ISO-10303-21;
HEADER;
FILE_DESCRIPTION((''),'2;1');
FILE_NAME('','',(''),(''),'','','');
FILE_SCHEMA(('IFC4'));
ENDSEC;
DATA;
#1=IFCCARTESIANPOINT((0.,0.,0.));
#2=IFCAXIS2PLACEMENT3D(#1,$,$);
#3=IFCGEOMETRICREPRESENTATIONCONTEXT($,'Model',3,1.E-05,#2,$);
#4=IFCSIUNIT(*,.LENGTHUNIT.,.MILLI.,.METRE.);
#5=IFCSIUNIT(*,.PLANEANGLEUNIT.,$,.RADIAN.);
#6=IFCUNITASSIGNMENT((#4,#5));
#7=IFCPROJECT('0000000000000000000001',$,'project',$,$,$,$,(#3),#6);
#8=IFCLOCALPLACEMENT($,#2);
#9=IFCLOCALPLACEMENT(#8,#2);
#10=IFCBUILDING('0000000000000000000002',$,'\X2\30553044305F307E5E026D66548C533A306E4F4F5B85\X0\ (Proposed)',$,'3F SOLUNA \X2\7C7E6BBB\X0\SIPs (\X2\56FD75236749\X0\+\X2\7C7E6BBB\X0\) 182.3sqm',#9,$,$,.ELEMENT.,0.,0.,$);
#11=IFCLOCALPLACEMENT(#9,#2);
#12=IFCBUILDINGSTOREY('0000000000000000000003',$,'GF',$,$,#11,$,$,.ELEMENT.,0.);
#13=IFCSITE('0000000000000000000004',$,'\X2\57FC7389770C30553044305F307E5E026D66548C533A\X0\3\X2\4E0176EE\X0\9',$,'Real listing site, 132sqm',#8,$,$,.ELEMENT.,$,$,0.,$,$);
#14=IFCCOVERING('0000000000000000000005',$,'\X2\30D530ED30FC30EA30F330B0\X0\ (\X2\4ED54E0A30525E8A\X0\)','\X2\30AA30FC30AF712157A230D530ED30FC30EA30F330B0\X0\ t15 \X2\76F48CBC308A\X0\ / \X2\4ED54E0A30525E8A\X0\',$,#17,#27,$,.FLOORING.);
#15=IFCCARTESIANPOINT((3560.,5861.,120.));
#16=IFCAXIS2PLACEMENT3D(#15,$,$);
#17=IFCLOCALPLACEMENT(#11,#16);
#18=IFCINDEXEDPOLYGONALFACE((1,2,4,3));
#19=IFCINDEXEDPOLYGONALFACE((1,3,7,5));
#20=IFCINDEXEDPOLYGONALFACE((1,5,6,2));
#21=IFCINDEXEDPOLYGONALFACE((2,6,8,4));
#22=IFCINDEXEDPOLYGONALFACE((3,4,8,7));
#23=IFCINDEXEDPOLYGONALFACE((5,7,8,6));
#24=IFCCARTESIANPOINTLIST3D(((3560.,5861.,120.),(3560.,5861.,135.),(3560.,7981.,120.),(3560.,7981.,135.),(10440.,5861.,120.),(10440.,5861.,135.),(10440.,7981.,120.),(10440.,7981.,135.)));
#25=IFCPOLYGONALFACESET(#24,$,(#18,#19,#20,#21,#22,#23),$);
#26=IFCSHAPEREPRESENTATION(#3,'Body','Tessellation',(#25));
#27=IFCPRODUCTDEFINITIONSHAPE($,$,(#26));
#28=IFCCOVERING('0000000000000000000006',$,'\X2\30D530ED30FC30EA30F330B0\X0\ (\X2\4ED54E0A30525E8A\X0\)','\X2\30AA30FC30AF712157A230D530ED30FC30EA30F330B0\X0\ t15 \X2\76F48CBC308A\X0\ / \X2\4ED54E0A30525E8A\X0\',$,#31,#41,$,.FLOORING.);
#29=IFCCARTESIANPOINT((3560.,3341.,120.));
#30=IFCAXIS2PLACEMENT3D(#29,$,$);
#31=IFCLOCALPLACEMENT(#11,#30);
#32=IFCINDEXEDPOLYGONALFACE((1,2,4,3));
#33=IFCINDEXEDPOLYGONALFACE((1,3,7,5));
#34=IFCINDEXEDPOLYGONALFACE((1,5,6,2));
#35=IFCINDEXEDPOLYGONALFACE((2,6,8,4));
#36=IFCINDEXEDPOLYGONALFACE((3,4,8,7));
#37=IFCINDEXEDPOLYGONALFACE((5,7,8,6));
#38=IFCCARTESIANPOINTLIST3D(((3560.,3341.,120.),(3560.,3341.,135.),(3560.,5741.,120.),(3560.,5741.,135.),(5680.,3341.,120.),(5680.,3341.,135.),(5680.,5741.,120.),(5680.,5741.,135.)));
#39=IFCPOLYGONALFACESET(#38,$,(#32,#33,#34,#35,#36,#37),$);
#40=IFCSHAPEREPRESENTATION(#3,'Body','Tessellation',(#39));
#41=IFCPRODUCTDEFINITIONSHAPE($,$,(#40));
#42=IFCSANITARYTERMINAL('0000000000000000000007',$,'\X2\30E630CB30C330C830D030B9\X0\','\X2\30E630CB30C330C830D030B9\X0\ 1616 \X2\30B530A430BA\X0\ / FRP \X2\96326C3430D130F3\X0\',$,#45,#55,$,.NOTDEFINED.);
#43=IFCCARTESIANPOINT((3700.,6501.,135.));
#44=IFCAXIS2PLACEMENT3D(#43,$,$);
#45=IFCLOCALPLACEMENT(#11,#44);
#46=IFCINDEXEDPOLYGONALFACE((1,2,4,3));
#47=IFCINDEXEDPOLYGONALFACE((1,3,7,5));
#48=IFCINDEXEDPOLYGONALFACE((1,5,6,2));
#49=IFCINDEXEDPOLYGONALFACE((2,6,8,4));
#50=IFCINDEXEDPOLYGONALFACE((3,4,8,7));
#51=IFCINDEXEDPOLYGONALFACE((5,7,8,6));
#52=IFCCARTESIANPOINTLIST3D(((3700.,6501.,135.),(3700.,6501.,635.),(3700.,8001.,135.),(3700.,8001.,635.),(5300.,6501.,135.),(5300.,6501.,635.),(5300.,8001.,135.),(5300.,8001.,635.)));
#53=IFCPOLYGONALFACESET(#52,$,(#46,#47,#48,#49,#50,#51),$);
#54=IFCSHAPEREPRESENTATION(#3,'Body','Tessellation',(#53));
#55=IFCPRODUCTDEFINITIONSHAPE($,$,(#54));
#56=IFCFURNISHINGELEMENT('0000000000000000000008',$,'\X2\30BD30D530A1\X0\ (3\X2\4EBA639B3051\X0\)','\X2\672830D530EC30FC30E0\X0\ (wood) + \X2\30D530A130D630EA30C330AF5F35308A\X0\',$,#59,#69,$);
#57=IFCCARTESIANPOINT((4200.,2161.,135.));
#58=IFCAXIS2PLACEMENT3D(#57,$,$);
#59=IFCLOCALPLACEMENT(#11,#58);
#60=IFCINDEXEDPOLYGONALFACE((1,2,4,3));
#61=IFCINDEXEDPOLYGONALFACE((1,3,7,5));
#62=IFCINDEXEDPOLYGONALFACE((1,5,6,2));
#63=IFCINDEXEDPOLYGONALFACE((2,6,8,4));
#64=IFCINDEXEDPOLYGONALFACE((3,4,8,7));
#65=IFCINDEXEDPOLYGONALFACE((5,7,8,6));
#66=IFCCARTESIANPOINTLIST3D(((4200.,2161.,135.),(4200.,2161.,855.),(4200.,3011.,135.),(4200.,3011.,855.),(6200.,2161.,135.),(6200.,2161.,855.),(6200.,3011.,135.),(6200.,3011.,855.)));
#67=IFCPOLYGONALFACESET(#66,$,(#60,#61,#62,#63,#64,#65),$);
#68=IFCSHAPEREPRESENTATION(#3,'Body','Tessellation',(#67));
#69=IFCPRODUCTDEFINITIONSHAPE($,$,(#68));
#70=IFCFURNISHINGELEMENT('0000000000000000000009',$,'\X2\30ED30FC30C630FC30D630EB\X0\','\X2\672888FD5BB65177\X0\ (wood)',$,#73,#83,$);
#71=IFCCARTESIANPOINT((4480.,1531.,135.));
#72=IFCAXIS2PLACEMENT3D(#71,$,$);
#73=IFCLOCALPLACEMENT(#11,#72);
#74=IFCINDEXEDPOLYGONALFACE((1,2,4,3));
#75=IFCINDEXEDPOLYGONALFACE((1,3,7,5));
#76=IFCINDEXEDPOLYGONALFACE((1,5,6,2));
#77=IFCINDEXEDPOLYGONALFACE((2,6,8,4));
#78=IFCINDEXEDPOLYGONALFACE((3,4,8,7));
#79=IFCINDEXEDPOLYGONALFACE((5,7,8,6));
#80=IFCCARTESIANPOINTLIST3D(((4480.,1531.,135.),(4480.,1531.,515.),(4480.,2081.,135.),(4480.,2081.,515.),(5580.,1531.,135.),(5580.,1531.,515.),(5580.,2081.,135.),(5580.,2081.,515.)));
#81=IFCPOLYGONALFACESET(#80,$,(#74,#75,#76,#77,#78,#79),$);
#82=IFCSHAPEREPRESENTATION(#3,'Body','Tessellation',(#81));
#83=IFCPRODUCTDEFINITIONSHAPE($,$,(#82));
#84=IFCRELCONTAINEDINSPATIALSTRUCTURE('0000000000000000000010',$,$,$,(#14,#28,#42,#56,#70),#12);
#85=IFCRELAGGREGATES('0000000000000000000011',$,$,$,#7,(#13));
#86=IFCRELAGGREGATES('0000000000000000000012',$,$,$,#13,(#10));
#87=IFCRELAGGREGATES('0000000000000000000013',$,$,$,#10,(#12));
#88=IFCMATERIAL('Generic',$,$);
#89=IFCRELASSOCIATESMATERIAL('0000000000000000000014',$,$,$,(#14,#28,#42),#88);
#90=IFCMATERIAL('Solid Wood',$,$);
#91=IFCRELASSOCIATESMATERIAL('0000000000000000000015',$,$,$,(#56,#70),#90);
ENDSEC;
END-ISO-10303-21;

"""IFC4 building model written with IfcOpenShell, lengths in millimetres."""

from ifc_helpers import new_model, si_unit, frame, frame_2d, origin, place, context, project, spatial, rectangle, extrude, material, element, save


model = new_model("IFC4")

# Units and contexts
model_context = context("Model", 3, precision=1e-05, world=origin())
ifc_project = project(units=[si_unit("LENGTHUNIT", "METRE", prefix="MILLI"), si_unit("PLANEANGLEUNIT", "RADIAN")], contexts=[model_context])

# Site, building, storey
site_placement = place(None, origin())
site = spatial("IfcSite", under=ifc_project, at=site_placement, Name="埼玉県さいたま市浦和区3丁目9", ObjectType="Real listing site, 132sqm", CompositionType="ELEMENT", RefElevation=0.0)
building_placement = place(site_placement, origin())
building = spatial("IfcBuilding", under=site, at=building_placement, Name="さいたま市浦和区の住宅 (Proposed)", ObjectType="3F SOLUNA 籾殻SIPs (国産杉+籾殻) 182.3sqm", CompositionType="ELEMENT", ElevationOfRefHeight=0.0, ElevationOfTerrain=0.0)
storey_placement = place(building_placement, origin())
storey = spatial("IfcBuildingStorey", under=building, at=storey_placement, Name="GF", CompositionType="ELEMENT", Elevation=0.0)

# Shared definitions
ifc_material_1 = material(Name="Solid Wood")

# Coverings
ifc_material_2 = material(Name="Generic")
covering_1_placement = place(storey_placement, frame((3560.0, 5861.0, 120.0)))
element("IfcCovering", 1, at=covering_1_placement, inside=storey, material=ifc_material_2, Name="フローリング (仕上げ床)", Description="オーク無垢フローリング t15 直貼り / 仕上げ床", PredefinedType="FLOORING", context=model_context, shape_type="SweptSolid", body=[
    extrude(rectangle(XDim=6880.0, YDim=2120.0, at=frame_2d((3440.0, 1060.0))), frame((3560.0, 5861.0, 120.0)), (0.0, 0.0, 1.0), 15.0),
])
covering_2_placement = place(storey_placement, frame((3560.0, 3341.0, 120.0)))
element("IfcCovering", 2, at=covering_2_placement, inside=storey, material=ifc_material_2, Name="フローリング (仕上げ床)", Description="オーク無垢フローリング t15 直貼り / 仕上げ床", PredefinedType="FLOORING", context=model_context, shape_type="SweptSolid", body=[
    extrude(rectangle(XDim=2120.0, YDim=2400.0, at=frame_2d((1060.0, 1200.0))), frame((3560.0, 3341.0, 120.0)), (0.0, 0.0, 1.0), 15.0),
])

# Sanitary terminal
sanitary_terminal_placement = place(storey_placement, frame((3700.0, 6501.0, 135.0)))
element("IfcSanitaryTerminal", 3, at=sanitary_terminal_placement, inside=storey, material=ifc_material_2, Name="ユニットバス", Description="ユニットバス 1616 サイズ / FRP 防水パン", PredefinedType="NOTDEFINED", context=model_context, shape_type="SweptSolid", body=[
    extrude(rectangle(XDim=1600.0, YDim=1500.0, at=frame_2d((800.0, 750.0))), frame((3700.0, 6501.0, 135.0)), (0.0, 0.0, 1.0), 500.0),
])

# Furnishing elements
furnishing_1_placement = place(storey_placement, frame((4200.0, 2161.0, 135.0)))
element("IfcFurnishingElement", 4, at=furnishing_1_placement, inside=storey, material=ifc_material_1, Name="ソファ (3人掛け)", Description="木フレーム (wood) + ファブリック張り", context=model_context, shape_type="SweptSolid", body=[
    extrude(rectangle(XDim=2000.0, YDim=850.0, at=frame_2d((1000.0, 425.0))), frame((4200.0, 2161.0, 135.0)), (0.0, 0.0, 1.0), 720.0),
])
furnishing_2_placement = place(storey_placement, frame((4480.0, 1531.0, 135.0)))
element("IfcFurnishingElement", 5, at=furnishing_2_placement, inside=storey, material=ifc_material_1, Name="ローテーブル", Description="木製家具 (wood)", context=model_context, shape_type="SweptSolid", body=[
    extrude(rectangle(XDim=1100.0, YDim=550.0, at=frame_2d((550.0, 275.0))), frame((4480.0, 1531.0, 135.0)), (0.0, 0.0, 1.0), 380.0),
])

save(model, "model.ifc")
